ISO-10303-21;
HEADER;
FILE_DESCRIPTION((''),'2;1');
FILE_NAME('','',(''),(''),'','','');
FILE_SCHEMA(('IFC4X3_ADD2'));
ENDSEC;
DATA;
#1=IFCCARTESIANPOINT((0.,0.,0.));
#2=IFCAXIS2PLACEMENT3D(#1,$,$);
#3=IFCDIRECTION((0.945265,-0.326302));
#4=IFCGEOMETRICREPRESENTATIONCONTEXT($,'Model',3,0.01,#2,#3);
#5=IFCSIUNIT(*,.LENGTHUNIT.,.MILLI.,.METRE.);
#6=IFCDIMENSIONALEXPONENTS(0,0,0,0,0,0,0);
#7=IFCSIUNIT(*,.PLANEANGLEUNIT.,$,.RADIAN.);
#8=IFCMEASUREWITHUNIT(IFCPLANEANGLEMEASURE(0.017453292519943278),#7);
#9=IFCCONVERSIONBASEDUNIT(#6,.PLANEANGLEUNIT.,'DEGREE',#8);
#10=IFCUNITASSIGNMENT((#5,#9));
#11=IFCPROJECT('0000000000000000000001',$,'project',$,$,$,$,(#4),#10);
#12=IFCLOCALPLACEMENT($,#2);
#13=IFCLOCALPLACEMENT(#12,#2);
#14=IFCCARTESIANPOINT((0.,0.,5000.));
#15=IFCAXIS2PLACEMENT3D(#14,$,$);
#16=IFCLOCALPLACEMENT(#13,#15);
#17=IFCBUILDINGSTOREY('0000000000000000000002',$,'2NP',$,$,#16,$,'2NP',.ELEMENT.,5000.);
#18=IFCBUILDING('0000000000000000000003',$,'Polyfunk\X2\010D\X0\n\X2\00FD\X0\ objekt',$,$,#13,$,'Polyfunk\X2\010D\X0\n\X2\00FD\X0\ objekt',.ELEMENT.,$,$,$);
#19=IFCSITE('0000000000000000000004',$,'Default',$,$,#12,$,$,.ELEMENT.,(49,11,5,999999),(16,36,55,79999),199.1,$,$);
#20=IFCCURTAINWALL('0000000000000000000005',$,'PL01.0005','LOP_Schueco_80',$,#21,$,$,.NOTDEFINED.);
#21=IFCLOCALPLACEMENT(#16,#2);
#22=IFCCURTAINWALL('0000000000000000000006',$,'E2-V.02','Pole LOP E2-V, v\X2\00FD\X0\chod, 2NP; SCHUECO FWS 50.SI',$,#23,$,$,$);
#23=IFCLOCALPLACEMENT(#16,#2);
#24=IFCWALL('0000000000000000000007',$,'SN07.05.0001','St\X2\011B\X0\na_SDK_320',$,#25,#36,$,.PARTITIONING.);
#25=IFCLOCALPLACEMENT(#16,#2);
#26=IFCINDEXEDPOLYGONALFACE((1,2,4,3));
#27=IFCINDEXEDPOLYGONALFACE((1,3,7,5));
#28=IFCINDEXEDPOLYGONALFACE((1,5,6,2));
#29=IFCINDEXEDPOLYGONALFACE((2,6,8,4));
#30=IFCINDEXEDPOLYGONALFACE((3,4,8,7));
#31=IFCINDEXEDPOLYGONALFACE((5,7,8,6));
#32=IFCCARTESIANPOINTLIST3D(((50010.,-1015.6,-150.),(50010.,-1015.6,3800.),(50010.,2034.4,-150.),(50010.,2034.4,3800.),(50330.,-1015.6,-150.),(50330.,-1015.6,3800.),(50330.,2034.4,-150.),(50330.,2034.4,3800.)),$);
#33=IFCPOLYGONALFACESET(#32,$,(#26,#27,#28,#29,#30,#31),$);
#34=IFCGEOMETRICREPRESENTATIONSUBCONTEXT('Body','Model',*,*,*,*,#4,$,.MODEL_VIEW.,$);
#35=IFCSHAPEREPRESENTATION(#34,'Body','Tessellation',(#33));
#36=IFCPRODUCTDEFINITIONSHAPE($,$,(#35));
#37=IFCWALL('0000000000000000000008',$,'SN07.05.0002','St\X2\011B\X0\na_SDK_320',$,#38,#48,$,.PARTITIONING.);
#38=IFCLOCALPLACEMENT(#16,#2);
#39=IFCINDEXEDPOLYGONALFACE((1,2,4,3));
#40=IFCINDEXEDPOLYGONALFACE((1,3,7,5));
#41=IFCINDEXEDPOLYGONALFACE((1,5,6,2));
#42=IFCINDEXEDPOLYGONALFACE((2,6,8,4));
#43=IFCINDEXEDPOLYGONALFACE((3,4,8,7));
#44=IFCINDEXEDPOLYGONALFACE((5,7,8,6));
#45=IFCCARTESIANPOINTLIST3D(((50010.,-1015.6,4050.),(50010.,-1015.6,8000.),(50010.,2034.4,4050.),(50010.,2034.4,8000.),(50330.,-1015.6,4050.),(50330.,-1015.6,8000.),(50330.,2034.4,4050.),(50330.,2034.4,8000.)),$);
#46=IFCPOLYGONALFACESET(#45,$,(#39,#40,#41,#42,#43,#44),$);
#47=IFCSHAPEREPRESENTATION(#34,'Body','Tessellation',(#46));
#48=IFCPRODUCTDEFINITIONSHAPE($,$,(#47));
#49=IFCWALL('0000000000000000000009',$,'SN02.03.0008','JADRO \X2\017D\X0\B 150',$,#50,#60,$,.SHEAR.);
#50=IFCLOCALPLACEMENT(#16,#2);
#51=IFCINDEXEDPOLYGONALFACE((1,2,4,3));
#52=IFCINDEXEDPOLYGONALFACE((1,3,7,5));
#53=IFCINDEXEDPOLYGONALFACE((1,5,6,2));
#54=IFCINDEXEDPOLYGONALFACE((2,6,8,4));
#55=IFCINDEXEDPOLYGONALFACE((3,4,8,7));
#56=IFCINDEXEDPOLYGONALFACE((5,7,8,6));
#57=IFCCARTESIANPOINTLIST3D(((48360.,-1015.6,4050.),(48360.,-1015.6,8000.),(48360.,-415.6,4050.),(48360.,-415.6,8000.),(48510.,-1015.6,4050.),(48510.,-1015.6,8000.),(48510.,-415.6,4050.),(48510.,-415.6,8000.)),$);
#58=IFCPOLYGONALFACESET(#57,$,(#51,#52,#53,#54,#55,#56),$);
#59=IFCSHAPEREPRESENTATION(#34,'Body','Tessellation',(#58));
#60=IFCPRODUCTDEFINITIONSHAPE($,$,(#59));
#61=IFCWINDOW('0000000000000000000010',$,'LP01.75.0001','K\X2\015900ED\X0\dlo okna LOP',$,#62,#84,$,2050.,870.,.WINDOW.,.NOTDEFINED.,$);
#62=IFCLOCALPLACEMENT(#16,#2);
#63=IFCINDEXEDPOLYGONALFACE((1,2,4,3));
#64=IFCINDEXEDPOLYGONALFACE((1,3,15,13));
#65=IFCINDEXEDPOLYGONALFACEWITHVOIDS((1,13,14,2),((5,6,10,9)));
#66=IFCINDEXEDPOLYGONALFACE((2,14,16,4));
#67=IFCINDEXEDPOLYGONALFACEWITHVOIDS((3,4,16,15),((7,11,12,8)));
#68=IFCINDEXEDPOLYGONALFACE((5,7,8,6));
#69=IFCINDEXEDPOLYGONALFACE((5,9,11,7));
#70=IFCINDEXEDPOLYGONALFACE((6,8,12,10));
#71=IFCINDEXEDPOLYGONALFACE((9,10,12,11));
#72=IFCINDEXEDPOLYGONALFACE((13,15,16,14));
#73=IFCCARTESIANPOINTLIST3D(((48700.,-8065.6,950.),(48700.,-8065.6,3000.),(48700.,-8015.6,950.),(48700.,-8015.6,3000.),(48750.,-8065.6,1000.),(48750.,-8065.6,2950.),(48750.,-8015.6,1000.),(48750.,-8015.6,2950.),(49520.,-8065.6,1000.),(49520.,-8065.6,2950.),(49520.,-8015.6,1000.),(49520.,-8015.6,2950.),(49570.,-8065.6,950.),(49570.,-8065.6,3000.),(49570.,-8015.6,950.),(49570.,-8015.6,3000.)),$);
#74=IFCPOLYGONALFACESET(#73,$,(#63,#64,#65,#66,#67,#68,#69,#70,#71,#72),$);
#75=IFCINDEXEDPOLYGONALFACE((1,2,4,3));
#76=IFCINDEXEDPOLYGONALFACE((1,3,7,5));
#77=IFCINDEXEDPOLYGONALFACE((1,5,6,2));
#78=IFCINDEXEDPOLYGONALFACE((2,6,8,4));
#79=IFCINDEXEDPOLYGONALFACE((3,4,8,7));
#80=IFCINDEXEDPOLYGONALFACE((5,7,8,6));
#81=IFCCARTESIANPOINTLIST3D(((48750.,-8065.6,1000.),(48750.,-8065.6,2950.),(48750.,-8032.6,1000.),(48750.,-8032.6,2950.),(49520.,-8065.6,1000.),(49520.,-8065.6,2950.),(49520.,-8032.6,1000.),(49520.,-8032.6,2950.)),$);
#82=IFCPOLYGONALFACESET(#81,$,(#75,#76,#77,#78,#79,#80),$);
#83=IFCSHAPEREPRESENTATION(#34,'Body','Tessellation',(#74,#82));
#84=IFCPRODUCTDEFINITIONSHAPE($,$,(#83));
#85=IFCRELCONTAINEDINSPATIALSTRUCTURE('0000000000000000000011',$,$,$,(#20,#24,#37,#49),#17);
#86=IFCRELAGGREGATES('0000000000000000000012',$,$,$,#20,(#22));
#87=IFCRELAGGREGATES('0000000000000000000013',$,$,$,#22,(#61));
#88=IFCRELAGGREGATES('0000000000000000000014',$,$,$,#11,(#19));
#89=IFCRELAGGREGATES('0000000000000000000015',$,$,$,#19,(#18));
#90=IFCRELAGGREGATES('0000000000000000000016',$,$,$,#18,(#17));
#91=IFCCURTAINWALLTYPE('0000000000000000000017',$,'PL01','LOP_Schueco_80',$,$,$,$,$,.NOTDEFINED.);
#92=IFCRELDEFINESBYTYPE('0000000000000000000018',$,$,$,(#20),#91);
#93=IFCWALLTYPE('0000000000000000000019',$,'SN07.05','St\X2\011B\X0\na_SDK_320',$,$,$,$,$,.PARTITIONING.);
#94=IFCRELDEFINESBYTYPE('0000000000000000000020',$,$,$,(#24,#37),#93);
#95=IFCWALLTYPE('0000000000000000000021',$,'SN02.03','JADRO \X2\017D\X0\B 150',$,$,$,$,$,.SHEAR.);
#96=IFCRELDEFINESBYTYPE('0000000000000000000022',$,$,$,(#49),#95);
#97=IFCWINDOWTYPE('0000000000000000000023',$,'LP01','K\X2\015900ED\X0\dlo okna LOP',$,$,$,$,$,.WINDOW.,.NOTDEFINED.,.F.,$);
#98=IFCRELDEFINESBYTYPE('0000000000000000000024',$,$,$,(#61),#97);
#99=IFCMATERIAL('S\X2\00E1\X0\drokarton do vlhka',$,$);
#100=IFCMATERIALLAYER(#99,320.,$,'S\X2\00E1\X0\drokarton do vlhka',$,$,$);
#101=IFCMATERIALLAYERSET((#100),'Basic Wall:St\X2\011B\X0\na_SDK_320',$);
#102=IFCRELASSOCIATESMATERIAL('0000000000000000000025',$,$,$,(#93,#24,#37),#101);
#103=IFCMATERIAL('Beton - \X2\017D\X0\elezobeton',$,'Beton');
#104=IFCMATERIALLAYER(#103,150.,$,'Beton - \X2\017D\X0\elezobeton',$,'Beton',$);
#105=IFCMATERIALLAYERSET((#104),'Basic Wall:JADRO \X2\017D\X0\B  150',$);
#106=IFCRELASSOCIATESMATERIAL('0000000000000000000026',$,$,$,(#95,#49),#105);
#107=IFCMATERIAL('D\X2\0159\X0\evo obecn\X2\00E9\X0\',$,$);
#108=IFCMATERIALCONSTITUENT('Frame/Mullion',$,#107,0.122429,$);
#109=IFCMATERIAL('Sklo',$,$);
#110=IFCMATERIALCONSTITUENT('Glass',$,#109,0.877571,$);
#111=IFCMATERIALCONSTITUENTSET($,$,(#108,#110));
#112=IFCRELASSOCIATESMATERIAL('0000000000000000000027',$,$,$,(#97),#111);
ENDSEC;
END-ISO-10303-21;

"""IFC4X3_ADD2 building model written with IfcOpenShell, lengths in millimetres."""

from ifc_helpers import new_model, entity, si_unit, converted_unit, direction, frame, frame_2d, origin, place, context, subcontext, project, spatial, polyline, rectangle, outline, extrude, clip, bounded_halfspace, source, transform, mapped, material, layer, layer_set, constituent, constituent_set, type_object, type_shapes, element, aggregate, save


model = new_model("IFC4X3_ADD2")

# Units and contexts
model_context = context("Model", 3, precision=0.01, world=origin(), true_north=direction((0.945265, -0.326302)))
body_context = subcontext(model_context, "Body", "Model", "MODEL_VIEW")
ifc_project = project(units=[si_unit("LENGTHUNIT", "METRE", prefix="MILLI"), converted_unit("PLANEANGLEUNIT", "DEGREE", entity("IfcPlaneAngleMeasure", 0.017453292519943278), si_unit("PLANEANGLEUNIT", "RADIAN"), dimensions=[0, 0, 0, 0, 0, 0, 0])], contexts=[model_context])

# Site, building, storey
site_placement = place(None, origin())
site = spatial("IfcSite", under=ifc_project, at=site_placement, Name="Default", CompositionType="ELEMENT", RefLatitude=(49, 11, 5, 999999), RefLongitude=(16, 36, 55, 79999), RefElevation=199.1)
building_placement = place(site_placement, origin())
building = spatial("IfcBuilding", under=site, at=building_placement, Name="Polyfunkčný objekt", LongName="Polyfunkčný objekt", CompositionType="ELEMENT")
storey_placement = place(building_placement, frame((0.0, 0.0, 5000.0)))
storey = spatial("IfcBuildingStorey", under=building, at=storey_placement, Name="2NP", LongName="2NP", CompositionType="ELEMENT", Elevation=5000.0)

# Curtain walls
curtain_wall_type = type_object("IfcCurtainWallType", Name="PL01", Description="LOP_Schueco_80", PredefinedType="NOTDEFINED")
curtain_wall_1_placement = place(storey_placement, frame((0.0, 0.0, -5000.0)))
curtain_wall_1 = element("IfcCurtainWall", 1, at=curtain_wall_1_placement, inside=storey, type_object=curtain_wall_type, Name="PL01.0005", Description="LOP_Schueco_80", PredefinedType="NOTDEFINED")
curtain_wall_2 = element("IfcCurtainWall", 2, Name="E2-V.02", Description="Pole LOP E2-V, východ, 2NP; SCHUECO FWS 50.SI")
aggregate(curtain_wall_1, [curtain_wall_2])
ifc_material_1 = material(Name="Sklo")

# Walls
ifc_material_2 = material(Name="Sádrokarton do vlhka")
ifc_layer_1 = layer(ifc_material_2, 320.0, Name="Sádrokarton do vlhka")
ifc_layer_set_1 = layer_set([ifc_layer_1], Name="Basic Wall:Stěna_SDK_320")
wall_type_1 = type_object("IfcWallType", Name="SN07.05", Description="Stěna_SDK_320", PredefinedType="PARTITIONING", material=ifc_layer_set_1)
wall_1_placement = place(storey_placement, frame((50170.0, 2034.4, -150.0), z_axis=(0.0, 0.0, 1.0), x_axis=(0.0, -1.0, 0.0)))
element("IfcWall", 3, at=wall_1_placement, inside=storey, type_object=wall_type_1, material=ifc_layer_set_1, Name="SN07.05.0001", Description="Stěna_SDK_320", PredefinedType="PARTITIONING", context=body_context, shape_type="Clipping", body=[
    clip(clip(extrude(rectangle(XDim=3050.0, YDim=320.0, at=frame_2d((1525.0, 0.0), x_axis=(-1.0, 0.0))), origin(), (0.0, 0.0, 1.0), 3950.0), bounded_halfspace(frame((3050.0, -160.0, 0.0), z_axis=(0.0, 0.0, 1.0), x_axis=(0.0, -1.0, 0.0)), True, frame((3050.0, -160.0, 0.0)), polyline([(0.0, 0.0), (0.0, 320.0), (-1600.0, 320.0), (-1750.0, 320.0), (-2900.0, 320.0), (-3050.0, 320.0), (-3050.0, 0.0), (0.0, 0.0)]))), bounded_halfspace(frame((0.0, -160.0, 3950.0), z_axis=(0.0, 0.0, -1.0), x_axis=(0.0, 1.0, 0.0)), True, frame((0.0, -160.0, 3950.0)), polyline([(0.0, 0.0), (3050.0, 0.0), (3050.0, 320.0), (1450.0, 320.0), (1300.0, 320.0), (150.0, 320.0), (0.0, 320.0), (0.0, 0.0)]))),
])
wall_2_placement = place(storey_placement, frame((50170.0, 2034.4, 4050.0), z_axis=(0.0, 0.0, 1.0), x_axis=(0.0, -1.0, 0.0)))
element("IfcWall", 4, at=wall_2_placement, inside=storey, type_object=wall_type_1, material=ifc_layer_set_1, Name="SN07.05.0002", Description="Stěna_SDK_320", PredefinedType="PARTITIONING", context=body_context, shape_type="Clipping", body=[
    clip(clip(extrude(rectangle(XDim=3050.0, YDim=320.0, at=frame_2d((1525.0, 0.0), x_axis=(-1.0, 0.0))), origin(), (0.0, 0.0, 1.0), 3950.0), bounded_halfspace(frame((3050.0, -160.0, 0.0), z_axis=(0.0, 0.0, 1.0), x_axis=(0.0, -1.0, 0.0)), True, frame((3050.0, -160.0, 0.0)), polyline([(0.0, 0.0), (0.0, 320.0), (-1600.0, 320.0), (-1750.0, 320.0), (-2900.0, 320.0), (-3050.0, 320.0), (-3050.0, 0.0), (0.0, 0.0)]))), bounded_halfspace(frame((0.0, -160.0, 3950.0), z_axis=(0.0, 0.0, -1.0), x_axis=(0.0, 1.0, 0.0)), True, frame((0.0, -160.0, 3950.0)), polyline([(0.0, 0.0), (3050.0, 0.0), (3050.0, 320.0), (1450.0, 320.0), (1300.0, 320.0), (150.0, 320.0), (0.0, 320.0), (0.0, 0.0)]))),
])
ifc_material_3 = material(Name="Beton - Železobeton", Category="Beton")
ifc_layer_2 = layer(ifc_material_3, 150.0, Name="Beton - Železobeton", Category="Beton")
ifc_layer_set_2 = layer_set([ifc_layer_2], Name="Basic Wall:JADRO ŽB  150")
wall_type_2 = type_object("IfcWallType", Name="SN02.03", Description="JADRO ŽB 150", PredefinedType="SHEAR", material=ifc_layer_set_2)
wall_3_placement = place(storey_placement, frame((48435.0, -1015.6, 4050.0), z_axis=(0.0, 0.0, 1.0), x_axis=(0.0, 1.0, 0.0)))
element("IfcWall", 5, at=wall_3_placement, inside=storey, type_object=wall_type_2, material=ifc_layer_set_2, Name="SN02.03.0008", Description="JADRO ŽB 150", PredefinedType="SHEAR", context=body_context, shape_type="SweptSolid", body=[
    extrude(rectangle(XDim=600.0, YDim=150.0, at=frame_2d((300.0, 0.0), x_axis=(-1.0, 0.0))), origin(), (0.0, 0.0, 1.0), 3950.0),
])

# Window
ifc_material_4 = material(Name="Dřevo obecné")
ifc_constituent_1 = constituent(ifc_material_4, Name="Frame/Mullion", fraction=0.122429)
ifc_constituent_2 = constituent(ifc_material_1, Name="Glass", fraction=0.877571)
ifc_constituent_set = constituent_set(constituents=[ifc_constituent_1, ifc_constituent_2])
window_type = type_object("IfcWindowType", Name="LP01", Description="Křídlo okna LOP", ParameterTakesPrecedence=False, PartitioningType="NOTDEFINED", PredefinedType="WINDOW", material=ifc_constituent_set)
shared_shape_1 = source(origin(), body_context, "Body", "SweptSolid", [
    extrude(outline(polyline([(-1025.0, -435.0), (1025.0, -435.0), (1025.0, 435.0), (-1025.0, 435.0), (-1025.0, -435.0)]), holes=[polyline([(-975.0, -385.0), (-975.0, 385.0), (975.0, 385.0), (975.0, -385.0), (-975.0, -385.0)])]), frame((0.0, 50.0, 1025.0), z_axis=(0.0, -1.0, 0.0), x_axis=(0.0, 0.0, -1.0)), (0.0, 0.0, 1.0), 50.0),
    extrude(rectangle(XDim=770.0, YDim=33.0, at=frame_2d((0.0, 0.0), x_axis=(1.0, 0.0))), frame((0.0, 33.5, 50.0), z_axis=(0.0, 0.0, 1.0), x_axis=(-1.0, 0.0, 0.0)), (0.0, 0.0, 1.0), 1950.0),
])
type_shapes(window_type, [shared_shape_1])
window_placement = place(curtain_wall_1_placement, frame((49135.0, -8015.6, 5950.0), z_axis=(0.0, 0.0, 1.0), x_axis=(-1.0, 0.0, 0.0)))
window = element("IfcWindow", 6, at=window_placement, type_object=window_type, Name="LP01.75.0001", Description="Křídlo okna LOP", OverallHeight=2050.0, OverallWidth=870.0, PartitioningType="NOTDEFINED", PredefinedType="WINDOW", context=body_context, shape_type="MappedRepresentation", body=[
    mapped(shared_shape_1, transform((0.0, 0.0, 0.0), scale=1.0)),
])
aggregate(curtain_wall_2, [window])

save(model, "model.ifc")
